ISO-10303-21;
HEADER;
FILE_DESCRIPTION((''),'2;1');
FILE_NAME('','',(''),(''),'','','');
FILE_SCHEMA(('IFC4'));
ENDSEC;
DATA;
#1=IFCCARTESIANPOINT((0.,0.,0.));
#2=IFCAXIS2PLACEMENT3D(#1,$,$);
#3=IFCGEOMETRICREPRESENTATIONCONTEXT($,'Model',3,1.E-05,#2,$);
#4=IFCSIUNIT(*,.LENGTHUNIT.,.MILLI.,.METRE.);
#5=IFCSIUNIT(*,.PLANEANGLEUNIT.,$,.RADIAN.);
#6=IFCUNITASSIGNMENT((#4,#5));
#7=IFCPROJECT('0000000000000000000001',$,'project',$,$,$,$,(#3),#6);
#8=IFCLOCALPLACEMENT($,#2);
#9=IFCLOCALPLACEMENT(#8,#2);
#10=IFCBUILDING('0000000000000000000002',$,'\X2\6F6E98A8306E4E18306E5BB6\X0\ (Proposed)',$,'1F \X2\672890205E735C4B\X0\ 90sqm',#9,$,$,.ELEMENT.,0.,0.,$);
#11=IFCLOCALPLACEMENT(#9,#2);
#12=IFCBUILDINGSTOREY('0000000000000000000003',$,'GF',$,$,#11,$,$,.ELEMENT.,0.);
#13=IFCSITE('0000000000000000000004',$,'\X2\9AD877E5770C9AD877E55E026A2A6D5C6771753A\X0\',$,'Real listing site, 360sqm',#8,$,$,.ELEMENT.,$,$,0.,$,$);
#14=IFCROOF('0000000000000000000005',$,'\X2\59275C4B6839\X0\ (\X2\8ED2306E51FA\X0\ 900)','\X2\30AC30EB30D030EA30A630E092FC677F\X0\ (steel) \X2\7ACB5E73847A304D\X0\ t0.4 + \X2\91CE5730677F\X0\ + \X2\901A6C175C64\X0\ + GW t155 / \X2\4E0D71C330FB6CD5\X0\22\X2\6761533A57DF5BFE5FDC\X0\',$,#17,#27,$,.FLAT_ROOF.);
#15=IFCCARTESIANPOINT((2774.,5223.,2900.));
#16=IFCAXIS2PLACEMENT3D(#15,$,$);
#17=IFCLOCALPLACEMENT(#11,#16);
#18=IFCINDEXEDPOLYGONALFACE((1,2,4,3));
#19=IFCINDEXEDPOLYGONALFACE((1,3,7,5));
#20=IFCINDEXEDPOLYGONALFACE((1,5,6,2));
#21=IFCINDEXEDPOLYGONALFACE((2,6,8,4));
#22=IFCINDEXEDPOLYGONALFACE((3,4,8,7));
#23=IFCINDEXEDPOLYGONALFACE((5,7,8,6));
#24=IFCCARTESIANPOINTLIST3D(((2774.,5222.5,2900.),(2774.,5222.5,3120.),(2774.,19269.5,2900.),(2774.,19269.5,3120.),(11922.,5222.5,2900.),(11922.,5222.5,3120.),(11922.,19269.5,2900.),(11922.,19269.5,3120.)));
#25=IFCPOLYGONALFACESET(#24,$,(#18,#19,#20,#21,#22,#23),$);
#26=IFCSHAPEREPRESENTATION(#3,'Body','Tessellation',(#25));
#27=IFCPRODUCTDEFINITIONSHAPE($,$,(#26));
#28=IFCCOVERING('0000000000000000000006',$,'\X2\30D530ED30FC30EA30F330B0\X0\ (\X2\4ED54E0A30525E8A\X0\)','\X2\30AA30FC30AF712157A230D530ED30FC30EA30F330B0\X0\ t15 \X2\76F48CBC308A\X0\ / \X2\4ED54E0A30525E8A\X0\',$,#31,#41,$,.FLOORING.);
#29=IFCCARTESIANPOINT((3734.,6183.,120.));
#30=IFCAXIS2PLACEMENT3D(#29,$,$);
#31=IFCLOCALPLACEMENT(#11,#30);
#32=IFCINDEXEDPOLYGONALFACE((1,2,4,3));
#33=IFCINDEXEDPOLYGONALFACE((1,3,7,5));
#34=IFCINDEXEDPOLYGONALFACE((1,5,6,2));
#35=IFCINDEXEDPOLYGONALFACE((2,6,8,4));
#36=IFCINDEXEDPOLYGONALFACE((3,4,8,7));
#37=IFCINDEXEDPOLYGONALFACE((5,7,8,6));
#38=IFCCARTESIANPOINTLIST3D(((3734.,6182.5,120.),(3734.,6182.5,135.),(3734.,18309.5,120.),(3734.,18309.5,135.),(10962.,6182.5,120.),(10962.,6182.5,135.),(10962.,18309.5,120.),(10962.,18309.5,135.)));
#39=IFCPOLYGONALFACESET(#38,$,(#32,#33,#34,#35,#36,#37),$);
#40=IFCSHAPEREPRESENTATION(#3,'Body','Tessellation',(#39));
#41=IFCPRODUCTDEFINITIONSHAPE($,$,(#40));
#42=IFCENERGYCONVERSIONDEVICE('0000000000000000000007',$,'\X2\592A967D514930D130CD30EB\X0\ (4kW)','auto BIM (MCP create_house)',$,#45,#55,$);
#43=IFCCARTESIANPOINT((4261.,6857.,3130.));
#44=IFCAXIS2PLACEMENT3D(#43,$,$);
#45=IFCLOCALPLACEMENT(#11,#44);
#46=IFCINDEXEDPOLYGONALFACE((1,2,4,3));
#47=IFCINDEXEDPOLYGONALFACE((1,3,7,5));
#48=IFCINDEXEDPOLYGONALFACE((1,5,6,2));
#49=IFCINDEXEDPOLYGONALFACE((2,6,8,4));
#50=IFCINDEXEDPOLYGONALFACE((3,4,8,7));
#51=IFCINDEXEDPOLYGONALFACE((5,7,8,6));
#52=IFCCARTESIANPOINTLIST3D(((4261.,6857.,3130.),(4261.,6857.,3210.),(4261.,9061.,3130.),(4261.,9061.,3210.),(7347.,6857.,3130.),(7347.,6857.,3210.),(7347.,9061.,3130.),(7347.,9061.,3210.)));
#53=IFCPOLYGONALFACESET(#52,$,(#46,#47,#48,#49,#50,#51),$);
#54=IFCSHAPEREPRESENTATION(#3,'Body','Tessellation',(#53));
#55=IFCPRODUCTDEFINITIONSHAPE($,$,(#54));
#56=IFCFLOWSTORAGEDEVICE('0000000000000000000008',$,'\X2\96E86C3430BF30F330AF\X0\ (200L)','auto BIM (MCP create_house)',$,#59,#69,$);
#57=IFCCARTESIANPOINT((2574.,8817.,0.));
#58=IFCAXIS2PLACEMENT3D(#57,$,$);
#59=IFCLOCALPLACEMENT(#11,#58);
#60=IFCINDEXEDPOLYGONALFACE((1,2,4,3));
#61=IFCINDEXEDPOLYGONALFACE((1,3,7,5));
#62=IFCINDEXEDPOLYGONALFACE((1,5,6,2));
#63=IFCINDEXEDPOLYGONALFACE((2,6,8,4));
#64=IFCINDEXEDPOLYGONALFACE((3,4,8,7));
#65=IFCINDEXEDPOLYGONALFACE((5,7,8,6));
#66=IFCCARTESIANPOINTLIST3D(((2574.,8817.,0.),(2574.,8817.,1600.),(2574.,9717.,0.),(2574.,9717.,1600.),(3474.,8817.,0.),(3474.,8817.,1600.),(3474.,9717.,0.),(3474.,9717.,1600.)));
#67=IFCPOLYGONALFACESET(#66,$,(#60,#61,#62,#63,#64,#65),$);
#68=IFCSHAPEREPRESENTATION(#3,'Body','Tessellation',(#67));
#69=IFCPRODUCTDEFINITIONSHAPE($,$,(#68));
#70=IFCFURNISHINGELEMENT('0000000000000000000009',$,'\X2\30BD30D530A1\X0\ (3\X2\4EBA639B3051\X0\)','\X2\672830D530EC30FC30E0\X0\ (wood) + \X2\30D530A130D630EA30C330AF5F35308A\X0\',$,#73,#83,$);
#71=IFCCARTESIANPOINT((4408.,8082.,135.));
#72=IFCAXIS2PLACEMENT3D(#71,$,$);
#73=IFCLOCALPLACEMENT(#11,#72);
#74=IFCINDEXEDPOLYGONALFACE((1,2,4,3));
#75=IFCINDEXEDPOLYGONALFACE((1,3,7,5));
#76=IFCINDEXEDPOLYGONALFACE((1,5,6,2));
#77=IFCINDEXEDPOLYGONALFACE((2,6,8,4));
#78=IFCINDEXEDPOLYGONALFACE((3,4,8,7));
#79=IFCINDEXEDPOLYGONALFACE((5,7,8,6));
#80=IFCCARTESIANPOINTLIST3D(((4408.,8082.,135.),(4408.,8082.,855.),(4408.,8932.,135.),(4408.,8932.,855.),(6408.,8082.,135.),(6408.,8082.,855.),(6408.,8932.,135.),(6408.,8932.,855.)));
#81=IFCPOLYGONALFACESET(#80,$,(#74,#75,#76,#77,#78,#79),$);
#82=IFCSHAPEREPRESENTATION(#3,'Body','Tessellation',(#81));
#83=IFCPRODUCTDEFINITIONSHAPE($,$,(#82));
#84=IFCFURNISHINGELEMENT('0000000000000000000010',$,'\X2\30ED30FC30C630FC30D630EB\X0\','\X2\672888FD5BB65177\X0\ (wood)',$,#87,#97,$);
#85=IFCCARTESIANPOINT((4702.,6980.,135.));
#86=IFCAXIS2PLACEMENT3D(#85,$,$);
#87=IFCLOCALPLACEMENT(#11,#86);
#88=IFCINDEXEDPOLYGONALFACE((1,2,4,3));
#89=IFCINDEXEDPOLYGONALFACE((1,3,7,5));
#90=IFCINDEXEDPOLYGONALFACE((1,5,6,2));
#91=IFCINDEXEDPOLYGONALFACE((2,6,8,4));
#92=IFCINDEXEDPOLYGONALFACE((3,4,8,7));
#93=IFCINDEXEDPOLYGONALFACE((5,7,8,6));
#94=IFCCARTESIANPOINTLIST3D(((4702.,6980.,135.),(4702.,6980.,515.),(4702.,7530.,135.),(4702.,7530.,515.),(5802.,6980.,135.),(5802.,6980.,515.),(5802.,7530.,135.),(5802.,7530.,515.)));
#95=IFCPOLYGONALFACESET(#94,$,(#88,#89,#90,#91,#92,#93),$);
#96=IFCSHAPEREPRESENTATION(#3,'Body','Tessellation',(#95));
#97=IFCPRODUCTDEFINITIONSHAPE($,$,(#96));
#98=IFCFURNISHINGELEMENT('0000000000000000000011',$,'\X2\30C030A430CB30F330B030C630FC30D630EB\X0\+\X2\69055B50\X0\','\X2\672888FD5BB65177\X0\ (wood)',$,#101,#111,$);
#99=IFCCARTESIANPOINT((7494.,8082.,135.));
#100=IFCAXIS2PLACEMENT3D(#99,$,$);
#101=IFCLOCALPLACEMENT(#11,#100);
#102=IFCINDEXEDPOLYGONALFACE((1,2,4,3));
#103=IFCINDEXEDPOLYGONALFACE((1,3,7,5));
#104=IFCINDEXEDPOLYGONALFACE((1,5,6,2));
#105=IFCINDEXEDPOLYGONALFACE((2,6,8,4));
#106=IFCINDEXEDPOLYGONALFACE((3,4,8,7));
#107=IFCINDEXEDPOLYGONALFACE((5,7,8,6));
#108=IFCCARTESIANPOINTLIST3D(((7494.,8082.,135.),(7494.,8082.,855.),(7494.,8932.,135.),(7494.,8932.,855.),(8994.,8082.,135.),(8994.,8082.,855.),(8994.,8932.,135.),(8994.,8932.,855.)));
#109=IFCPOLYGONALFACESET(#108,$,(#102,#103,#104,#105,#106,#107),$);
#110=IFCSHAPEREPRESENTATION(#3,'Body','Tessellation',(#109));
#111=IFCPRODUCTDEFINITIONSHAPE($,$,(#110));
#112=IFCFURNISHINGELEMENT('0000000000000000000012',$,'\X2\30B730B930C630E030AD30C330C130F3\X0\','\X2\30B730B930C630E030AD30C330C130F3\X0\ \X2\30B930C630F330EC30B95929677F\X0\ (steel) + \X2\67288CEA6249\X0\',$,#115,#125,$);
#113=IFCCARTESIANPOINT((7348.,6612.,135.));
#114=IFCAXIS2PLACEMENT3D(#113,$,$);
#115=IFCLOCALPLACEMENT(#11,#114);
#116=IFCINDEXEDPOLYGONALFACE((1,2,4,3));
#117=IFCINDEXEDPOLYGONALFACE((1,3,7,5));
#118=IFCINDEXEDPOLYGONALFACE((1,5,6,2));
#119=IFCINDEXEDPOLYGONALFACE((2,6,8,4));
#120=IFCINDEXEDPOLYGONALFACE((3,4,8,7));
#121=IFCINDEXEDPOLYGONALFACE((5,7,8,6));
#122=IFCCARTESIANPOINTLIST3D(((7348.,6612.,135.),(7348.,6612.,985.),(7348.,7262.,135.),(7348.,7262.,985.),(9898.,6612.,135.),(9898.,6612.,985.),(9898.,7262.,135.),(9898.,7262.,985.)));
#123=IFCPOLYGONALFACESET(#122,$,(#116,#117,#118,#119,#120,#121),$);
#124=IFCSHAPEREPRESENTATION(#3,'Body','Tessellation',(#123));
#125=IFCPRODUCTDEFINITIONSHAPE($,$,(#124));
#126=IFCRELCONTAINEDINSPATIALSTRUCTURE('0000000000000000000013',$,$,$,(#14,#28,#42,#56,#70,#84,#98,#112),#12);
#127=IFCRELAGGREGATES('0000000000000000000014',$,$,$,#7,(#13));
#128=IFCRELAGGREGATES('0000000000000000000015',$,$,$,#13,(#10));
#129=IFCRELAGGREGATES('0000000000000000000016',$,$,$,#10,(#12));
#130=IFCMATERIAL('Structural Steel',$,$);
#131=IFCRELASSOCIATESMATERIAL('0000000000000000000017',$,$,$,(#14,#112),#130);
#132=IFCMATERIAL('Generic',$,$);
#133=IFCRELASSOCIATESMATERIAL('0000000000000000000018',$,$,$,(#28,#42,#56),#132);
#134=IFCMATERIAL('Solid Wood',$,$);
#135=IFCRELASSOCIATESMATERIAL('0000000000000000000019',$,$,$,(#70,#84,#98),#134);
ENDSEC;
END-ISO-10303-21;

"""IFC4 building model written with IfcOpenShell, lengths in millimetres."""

from ifc_helpers import new_model, si_unit, frame, frame_2d, origin, place, context, project, spatial, rectangle, extrude, material, element, save


model = new_model("IFC4")

# Units and contexts
model_context = context("Model", 3, precision=1e-05, world=origin())
ifc_project = project(units=[si_unit("LENGTHUNIT", "METRE", prefix="MILLI"), si_unit("PLANEANGLEUNIT", "RADIAN")], contexts=[model_context])

# Site, building, storey
site_placement = place(None, origin())
site = spatial("IfcSite", under=ifc_project, at=site_placement, Name="高知県高知市横浜東町", ObjectType="Real listing site, 360sqm", CompositionType="ELEMENT", RefElevation=0.0)
building_placement = place(site_placement, origin())
building = spatial("IfcBuilding", under=site, at=building_placement, Name="潮風の丘の家 (Proposed)", ObjectType="1F 木造平屋 90sqm", CompositionType="ELEMENT", ElevationOfRefHeight=0.0, ElevationOfTerrain=0.0)
storey_placement = place(building_placement, origin())
storey = spatial("IfcBuildingStorey", under=building, at=storey_placement, Name="GF", CompositionType="ELEMENT", Elevation=0.0)

# Shared definitions
ifc_material_1 = material(Name="Solid Wood")

# Roof
ifc_material_2 = material(Name="Structural Steel")
roof_placement = place(storey_placement, frame((2774.0, 5223.0, 2900.0)))
element("IfcRoof", 1, at=roof_placement, inside=storey, material=ifc_material_2, Name="大屋根 (軒の出 900)", Description="ガルバリウム鋼板 (steel) 立平葺き t0.4 + 野地板 + 通気層 + GW t155 / 不燃・法22条区域対応", PredefinedType="FLAT_ROOF", context=model_context, shape_type="SweptSolid", body=[
    extrude(rectangle(XDim=9148.0, YDim=14047.0, at=frame_2d((4574.0, 7023.0))), frame((2774.0, 5223.0, 2900.0)), (0.0, 0.0, 1.0), 220.0),
])

# Covering
ifc_material_3 = material(Name="Generic")
covering_placement = place(storey_placement, frame((3734.0, 6183.0, 120.0)))
element("IfcCovering", 2, at=covering_placement, inside=storey, material=ifc_material_3, Name="フローリング (仕上げ床)", Description="オーク無垢フローリング t15 直貼り / 仕上げ床", PredefinedType="FLOORING", context=model_context, shape_type="SweptSolid", body=[
    extrude(rectangle(XDim=7228.0, YDim=12127.0, at=frame_2d((3614.0, 6063.0))), frame((3734.0, 6183.0, 120.0)), (0.0, 0.0, 1.0), 15.0),
])

# Energy conversion device
energy_conversion_device_placement = place(storey_placement, frame((4261.0, 6857.0, 3130.0)))
element("IfcEnergyConversionDevice", 3, at=energy_conversion_device_placement, inside=storey, material=ifc_material_3, Name="太陽光パネル (4kW)", Description="auto BIM (MCP create_house)", context=model_context, shape_type="SweptSolid", body=[
    extrude(rectangle(XDim=3086.0, YDim=2204.0, at=frame_2d((1543.0, 1102.0))), frame((4261.0, 6857.0, 3130.0)), (0.0, 0.0, 1.0), 80.0),
])

# Flow storage device
flow_storage_device_placement = place(storey_placement, frame((2574.0, 8817.0, 0.0)))
element("IfcFlowStorageDevice", 4, at=flow_storage_device_placement, inside=storey, material=ifc_material_3, Name="雨水タンク (200L)", Description="auto BIM (MCP create_house)", context=model_context, shape_type="SweptSolid", body=[
    extrude(rectangle(XDim=900.0, YDim=900.0, at=frame_2d((450.0, 450.0))), frame((2574.0, 8817.0, 0.0)), (0.0, 0.0, 1.0), 1600.0),
])

# Furnishing elements
furnishing_1_placement = place(storey_placement, frame((4408.0, 8082.0, 135.0)))
element("IfcFurnishingElement", 5, at=furnishing_1_placement, inside=storey, material=ifc_material_1, Name="ソファ (3人掛け)", Description="木フレーム (wood) + ファブリック張り", context=model_context, shape_type="SweptSolid", body=[
    extrude(rectangle(XDim=2000.0, YDim=850.0, at=frame_2d((1000.0, 425.0))), frame((4408.0, 8082.0, 135.0)), (0.0, 0.0, 1.0), 720.0),
])
furnishing_2_placement = place(storey_placement, frame((4702.0, 6980.0, 135.0)))
element("IfcFurnishingElement", 6, at=furnishing_2_placement, inside=storey, material=ifc_material_1, Name="ローテーブル", Description="木製家具 (wood)", context=model_context, shape_type="SweptSolid", body=[
    extrude(rectangle(XDim=1100.0, YDim=550.0, at=frame_2d((550.0, 275.0))), frame((4702.0, 6980.0, 135.0)), (0.0, 0.0, 1.0), 380.0),
])
furnishing_3_placement = place(storey_placement, frame((7494.0, 8082.0, 135.0)))
element("IfcFurnishingElement", 7, at=furnishing_3_placement, inside=storey, material=ifc_material_1, Name="ダイニングテーブル+椅子", Description="木製家具 (wood)", context=model_context, shape_type="SweptSolid", body=[
    extrude(rectangle(XDim=1500.0, YDim=850.0, at=frame_2d((750.0, 425.0))), frame((7494.0, 8082.0, 135.0)), (0.0, 0.0, 1.0), 720.0),
])
furnishing_4_placement = place(storey_placement, frame((7348.0, 6612.0, 135.0)))
element("IfcFurnishingElement", 8, at=furnishing_4_placement, inside=storey, material=ifc_material_2, Name="システムキッチン", Description="システムキッチン ステンレス天板 (steel) + 木質扉", context=model_context, shape_type="SweptSolid", body=[
    extrude(rectangle(XDim=2550.0, YDim=650.0, at=frame_2d((1275.0, 325.0))), frame((7348.0, 6612.0, 135.0)), (0.0, 0.0, 1.0), 850.0),
])

save(model, "model.ifc")
